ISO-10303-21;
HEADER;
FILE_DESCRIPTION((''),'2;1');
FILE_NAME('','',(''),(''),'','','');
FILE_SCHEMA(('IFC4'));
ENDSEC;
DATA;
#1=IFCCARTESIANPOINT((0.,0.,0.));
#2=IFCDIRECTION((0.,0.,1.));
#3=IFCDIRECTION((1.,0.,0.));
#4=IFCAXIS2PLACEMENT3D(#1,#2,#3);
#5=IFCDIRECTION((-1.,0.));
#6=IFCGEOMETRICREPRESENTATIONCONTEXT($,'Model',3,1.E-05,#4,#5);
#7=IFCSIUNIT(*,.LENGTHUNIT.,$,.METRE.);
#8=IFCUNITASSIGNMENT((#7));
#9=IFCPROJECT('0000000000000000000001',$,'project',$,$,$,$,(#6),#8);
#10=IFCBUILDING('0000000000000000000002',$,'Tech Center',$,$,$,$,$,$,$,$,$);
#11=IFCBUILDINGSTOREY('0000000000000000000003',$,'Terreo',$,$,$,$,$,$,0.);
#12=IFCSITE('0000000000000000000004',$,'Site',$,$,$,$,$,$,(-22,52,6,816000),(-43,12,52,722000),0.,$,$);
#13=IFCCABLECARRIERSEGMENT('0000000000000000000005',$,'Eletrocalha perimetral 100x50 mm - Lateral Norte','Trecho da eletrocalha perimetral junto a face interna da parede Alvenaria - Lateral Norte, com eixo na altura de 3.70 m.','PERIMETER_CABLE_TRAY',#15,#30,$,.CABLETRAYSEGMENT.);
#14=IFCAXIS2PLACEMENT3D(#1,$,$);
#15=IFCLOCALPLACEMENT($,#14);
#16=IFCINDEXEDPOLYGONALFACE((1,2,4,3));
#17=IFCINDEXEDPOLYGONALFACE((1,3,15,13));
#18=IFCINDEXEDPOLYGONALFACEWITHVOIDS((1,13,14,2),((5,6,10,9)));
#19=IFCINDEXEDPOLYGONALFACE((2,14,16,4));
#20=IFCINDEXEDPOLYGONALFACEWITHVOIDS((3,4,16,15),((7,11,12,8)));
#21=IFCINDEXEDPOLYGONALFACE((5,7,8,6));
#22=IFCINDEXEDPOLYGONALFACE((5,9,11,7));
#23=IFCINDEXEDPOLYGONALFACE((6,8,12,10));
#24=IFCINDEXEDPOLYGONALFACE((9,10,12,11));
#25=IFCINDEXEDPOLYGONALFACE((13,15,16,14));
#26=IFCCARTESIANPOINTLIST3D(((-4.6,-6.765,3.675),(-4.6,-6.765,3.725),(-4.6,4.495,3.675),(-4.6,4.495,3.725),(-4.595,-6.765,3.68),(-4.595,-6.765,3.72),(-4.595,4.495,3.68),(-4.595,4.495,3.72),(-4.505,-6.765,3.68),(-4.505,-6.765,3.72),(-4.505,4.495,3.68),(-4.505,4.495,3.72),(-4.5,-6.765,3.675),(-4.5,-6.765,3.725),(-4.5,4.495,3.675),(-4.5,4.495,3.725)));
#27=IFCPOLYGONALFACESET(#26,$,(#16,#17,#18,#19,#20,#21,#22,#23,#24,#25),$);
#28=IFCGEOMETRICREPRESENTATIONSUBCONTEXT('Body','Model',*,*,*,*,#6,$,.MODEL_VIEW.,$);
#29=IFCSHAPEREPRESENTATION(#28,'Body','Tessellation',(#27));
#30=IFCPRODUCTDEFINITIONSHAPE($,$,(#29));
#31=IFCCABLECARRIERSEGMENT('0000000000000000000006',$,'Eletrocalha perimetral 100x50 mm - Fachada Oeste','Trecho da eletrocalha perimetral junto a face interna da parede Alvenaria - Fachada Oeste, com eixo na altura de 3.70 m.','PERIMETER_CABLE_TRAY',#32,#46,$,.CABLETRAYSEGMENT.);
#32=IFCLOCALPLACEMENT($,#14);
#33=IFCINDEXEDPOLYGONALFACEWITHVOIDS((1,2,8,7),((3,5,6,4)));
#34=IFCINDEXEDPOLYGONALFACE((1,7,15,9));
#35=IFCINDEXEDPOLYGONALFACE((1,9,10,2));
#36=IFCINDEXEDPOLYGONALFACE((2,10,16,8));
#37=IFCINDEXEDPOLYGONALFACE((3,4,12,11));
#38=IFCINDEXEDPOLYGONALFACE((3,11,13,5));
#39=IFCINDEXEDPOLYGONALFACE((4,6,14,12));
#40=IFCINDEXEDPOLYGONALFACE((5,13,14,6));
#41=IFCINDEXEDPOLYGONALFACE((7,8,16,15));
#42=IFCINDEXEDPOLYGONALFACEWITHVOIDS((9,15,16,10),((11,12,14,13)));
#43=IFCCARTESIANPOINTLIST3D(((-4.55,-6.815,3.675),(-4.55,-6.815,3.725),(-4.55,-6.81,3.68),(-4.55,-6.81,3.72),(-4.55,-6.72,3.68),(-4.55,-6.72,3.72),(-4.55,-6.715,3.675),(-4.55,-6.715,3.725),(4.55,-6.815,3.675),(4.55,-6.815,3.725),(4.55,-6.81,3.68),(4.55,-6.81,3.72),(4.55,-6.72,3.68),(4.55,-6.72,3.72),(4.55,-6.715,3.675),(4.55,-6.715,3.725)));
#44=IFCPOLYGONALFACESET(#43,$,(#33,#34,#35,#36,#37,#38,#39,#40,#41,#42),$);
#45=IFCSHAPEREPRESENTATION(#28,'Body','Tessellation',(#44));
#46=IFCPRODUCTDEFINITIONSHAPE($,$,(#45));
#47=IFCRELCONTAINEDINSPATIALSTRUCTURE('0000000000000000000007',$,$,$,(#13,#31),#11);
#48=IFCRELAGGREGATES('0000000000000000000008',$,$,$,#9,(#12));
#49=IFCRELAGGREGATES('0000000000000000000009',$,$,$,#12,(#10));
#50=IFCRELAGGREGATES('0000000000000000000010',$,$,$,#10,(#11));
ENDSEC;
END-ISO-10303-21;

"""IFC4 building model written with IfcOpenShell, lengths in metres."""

from ifc_helpers import new_model, si_unit, direction, frame, origin_with_axes, place, context, subcontext, project, spatial, hollow_rectangle, extrude, element, save


model = new_model("IFC4")

# Units and contexts
model_context = context("Model", 3, precision=1e-05, world=origin_with_axes(), true_north=direction((-1.0, 0.0)))
body_context = subcontext(model_context, "Body", "Model", "MODEL_VIEW")
ifc_project = project(units=[si_unit("LENGTHUNIT", "METRE")], contexts=[model_context])

# Site, building, storey
site = spatial("IfcSite", under=ifc_project, Name="Site", RefLatitude=(-22, 52, 6, 816000), RefLongitude=(-43, 12, 52, 722000), RefElevation=0.0)
building = spatial("IfcBuilding", under=site, Name="Tech Center")
storey = spatial("IfcBuildingStorey", under=building, Name="Terreo", Elevation=0.0)

# Cable carrier segments
cable_carrier_segment_1_placement = place(None, frame((-4.55, -6.765, 3.7)))
element("IfcCableCarrierSegment", 1, at=cable_carrier_segment_1_placement, inside=storey, Name="Eletrocalha perimetral 100x50 mm - Lateral Norte", Description="Trecho da eletrocalha perimetral junto a face interna da parede Alvenaria - Lateral Norte, com eixo na altura de 3.70 m.", ObjectType="PERIMETER_CABLE_TRAY", PredefinedType="CABLETRAYSEGMENT", context=body_context, shape_type="SweptSolid", body=[
    extrude(hollow_rectangle(XDim=0.1, YDim=0.05, WallThickness=0.005), frame((0.0, 0.0, 0.0), z_axis=(0.0, 1.0, 0.0), x_axis=(1.0, 0.0, 0.0)), (0.0, 0.0, 1.0), 11.26),
])
cable_carrier_segment_2_placement = place(None, frame((4.55, -6.765, 3.7)))
element("IfcCableCarrierSegment", 2, at=cable_carrier_segment_2_placement, inside=storey, Name="Eletrocalha perimetral 100x50 mm - Fachada Oeste", Description="Trecho da eletrocalha perimetral junto a face interna da parede Alvenaria - Fachada Oeste, com eixo na altura de 3.70 m.", ObjectType="PERIMETER_CABLE_TRAY", PredefinedType="CABLETRAYSEGMENT", context=body_context, shape_type="SweptSolid", body=[
    extrude(hollow_rectangle(XDim=0.1, YDim=0.05, WallThickness=0.005), frame((0.0, 0.0, 0.0), z_axis=(-1.0, 0.0, 0.0), x_axis=(0.0, 1.0, 0.0)), (0.0, 0.0, 1.0), 9.1),
])

save(model, "model.ifc")
